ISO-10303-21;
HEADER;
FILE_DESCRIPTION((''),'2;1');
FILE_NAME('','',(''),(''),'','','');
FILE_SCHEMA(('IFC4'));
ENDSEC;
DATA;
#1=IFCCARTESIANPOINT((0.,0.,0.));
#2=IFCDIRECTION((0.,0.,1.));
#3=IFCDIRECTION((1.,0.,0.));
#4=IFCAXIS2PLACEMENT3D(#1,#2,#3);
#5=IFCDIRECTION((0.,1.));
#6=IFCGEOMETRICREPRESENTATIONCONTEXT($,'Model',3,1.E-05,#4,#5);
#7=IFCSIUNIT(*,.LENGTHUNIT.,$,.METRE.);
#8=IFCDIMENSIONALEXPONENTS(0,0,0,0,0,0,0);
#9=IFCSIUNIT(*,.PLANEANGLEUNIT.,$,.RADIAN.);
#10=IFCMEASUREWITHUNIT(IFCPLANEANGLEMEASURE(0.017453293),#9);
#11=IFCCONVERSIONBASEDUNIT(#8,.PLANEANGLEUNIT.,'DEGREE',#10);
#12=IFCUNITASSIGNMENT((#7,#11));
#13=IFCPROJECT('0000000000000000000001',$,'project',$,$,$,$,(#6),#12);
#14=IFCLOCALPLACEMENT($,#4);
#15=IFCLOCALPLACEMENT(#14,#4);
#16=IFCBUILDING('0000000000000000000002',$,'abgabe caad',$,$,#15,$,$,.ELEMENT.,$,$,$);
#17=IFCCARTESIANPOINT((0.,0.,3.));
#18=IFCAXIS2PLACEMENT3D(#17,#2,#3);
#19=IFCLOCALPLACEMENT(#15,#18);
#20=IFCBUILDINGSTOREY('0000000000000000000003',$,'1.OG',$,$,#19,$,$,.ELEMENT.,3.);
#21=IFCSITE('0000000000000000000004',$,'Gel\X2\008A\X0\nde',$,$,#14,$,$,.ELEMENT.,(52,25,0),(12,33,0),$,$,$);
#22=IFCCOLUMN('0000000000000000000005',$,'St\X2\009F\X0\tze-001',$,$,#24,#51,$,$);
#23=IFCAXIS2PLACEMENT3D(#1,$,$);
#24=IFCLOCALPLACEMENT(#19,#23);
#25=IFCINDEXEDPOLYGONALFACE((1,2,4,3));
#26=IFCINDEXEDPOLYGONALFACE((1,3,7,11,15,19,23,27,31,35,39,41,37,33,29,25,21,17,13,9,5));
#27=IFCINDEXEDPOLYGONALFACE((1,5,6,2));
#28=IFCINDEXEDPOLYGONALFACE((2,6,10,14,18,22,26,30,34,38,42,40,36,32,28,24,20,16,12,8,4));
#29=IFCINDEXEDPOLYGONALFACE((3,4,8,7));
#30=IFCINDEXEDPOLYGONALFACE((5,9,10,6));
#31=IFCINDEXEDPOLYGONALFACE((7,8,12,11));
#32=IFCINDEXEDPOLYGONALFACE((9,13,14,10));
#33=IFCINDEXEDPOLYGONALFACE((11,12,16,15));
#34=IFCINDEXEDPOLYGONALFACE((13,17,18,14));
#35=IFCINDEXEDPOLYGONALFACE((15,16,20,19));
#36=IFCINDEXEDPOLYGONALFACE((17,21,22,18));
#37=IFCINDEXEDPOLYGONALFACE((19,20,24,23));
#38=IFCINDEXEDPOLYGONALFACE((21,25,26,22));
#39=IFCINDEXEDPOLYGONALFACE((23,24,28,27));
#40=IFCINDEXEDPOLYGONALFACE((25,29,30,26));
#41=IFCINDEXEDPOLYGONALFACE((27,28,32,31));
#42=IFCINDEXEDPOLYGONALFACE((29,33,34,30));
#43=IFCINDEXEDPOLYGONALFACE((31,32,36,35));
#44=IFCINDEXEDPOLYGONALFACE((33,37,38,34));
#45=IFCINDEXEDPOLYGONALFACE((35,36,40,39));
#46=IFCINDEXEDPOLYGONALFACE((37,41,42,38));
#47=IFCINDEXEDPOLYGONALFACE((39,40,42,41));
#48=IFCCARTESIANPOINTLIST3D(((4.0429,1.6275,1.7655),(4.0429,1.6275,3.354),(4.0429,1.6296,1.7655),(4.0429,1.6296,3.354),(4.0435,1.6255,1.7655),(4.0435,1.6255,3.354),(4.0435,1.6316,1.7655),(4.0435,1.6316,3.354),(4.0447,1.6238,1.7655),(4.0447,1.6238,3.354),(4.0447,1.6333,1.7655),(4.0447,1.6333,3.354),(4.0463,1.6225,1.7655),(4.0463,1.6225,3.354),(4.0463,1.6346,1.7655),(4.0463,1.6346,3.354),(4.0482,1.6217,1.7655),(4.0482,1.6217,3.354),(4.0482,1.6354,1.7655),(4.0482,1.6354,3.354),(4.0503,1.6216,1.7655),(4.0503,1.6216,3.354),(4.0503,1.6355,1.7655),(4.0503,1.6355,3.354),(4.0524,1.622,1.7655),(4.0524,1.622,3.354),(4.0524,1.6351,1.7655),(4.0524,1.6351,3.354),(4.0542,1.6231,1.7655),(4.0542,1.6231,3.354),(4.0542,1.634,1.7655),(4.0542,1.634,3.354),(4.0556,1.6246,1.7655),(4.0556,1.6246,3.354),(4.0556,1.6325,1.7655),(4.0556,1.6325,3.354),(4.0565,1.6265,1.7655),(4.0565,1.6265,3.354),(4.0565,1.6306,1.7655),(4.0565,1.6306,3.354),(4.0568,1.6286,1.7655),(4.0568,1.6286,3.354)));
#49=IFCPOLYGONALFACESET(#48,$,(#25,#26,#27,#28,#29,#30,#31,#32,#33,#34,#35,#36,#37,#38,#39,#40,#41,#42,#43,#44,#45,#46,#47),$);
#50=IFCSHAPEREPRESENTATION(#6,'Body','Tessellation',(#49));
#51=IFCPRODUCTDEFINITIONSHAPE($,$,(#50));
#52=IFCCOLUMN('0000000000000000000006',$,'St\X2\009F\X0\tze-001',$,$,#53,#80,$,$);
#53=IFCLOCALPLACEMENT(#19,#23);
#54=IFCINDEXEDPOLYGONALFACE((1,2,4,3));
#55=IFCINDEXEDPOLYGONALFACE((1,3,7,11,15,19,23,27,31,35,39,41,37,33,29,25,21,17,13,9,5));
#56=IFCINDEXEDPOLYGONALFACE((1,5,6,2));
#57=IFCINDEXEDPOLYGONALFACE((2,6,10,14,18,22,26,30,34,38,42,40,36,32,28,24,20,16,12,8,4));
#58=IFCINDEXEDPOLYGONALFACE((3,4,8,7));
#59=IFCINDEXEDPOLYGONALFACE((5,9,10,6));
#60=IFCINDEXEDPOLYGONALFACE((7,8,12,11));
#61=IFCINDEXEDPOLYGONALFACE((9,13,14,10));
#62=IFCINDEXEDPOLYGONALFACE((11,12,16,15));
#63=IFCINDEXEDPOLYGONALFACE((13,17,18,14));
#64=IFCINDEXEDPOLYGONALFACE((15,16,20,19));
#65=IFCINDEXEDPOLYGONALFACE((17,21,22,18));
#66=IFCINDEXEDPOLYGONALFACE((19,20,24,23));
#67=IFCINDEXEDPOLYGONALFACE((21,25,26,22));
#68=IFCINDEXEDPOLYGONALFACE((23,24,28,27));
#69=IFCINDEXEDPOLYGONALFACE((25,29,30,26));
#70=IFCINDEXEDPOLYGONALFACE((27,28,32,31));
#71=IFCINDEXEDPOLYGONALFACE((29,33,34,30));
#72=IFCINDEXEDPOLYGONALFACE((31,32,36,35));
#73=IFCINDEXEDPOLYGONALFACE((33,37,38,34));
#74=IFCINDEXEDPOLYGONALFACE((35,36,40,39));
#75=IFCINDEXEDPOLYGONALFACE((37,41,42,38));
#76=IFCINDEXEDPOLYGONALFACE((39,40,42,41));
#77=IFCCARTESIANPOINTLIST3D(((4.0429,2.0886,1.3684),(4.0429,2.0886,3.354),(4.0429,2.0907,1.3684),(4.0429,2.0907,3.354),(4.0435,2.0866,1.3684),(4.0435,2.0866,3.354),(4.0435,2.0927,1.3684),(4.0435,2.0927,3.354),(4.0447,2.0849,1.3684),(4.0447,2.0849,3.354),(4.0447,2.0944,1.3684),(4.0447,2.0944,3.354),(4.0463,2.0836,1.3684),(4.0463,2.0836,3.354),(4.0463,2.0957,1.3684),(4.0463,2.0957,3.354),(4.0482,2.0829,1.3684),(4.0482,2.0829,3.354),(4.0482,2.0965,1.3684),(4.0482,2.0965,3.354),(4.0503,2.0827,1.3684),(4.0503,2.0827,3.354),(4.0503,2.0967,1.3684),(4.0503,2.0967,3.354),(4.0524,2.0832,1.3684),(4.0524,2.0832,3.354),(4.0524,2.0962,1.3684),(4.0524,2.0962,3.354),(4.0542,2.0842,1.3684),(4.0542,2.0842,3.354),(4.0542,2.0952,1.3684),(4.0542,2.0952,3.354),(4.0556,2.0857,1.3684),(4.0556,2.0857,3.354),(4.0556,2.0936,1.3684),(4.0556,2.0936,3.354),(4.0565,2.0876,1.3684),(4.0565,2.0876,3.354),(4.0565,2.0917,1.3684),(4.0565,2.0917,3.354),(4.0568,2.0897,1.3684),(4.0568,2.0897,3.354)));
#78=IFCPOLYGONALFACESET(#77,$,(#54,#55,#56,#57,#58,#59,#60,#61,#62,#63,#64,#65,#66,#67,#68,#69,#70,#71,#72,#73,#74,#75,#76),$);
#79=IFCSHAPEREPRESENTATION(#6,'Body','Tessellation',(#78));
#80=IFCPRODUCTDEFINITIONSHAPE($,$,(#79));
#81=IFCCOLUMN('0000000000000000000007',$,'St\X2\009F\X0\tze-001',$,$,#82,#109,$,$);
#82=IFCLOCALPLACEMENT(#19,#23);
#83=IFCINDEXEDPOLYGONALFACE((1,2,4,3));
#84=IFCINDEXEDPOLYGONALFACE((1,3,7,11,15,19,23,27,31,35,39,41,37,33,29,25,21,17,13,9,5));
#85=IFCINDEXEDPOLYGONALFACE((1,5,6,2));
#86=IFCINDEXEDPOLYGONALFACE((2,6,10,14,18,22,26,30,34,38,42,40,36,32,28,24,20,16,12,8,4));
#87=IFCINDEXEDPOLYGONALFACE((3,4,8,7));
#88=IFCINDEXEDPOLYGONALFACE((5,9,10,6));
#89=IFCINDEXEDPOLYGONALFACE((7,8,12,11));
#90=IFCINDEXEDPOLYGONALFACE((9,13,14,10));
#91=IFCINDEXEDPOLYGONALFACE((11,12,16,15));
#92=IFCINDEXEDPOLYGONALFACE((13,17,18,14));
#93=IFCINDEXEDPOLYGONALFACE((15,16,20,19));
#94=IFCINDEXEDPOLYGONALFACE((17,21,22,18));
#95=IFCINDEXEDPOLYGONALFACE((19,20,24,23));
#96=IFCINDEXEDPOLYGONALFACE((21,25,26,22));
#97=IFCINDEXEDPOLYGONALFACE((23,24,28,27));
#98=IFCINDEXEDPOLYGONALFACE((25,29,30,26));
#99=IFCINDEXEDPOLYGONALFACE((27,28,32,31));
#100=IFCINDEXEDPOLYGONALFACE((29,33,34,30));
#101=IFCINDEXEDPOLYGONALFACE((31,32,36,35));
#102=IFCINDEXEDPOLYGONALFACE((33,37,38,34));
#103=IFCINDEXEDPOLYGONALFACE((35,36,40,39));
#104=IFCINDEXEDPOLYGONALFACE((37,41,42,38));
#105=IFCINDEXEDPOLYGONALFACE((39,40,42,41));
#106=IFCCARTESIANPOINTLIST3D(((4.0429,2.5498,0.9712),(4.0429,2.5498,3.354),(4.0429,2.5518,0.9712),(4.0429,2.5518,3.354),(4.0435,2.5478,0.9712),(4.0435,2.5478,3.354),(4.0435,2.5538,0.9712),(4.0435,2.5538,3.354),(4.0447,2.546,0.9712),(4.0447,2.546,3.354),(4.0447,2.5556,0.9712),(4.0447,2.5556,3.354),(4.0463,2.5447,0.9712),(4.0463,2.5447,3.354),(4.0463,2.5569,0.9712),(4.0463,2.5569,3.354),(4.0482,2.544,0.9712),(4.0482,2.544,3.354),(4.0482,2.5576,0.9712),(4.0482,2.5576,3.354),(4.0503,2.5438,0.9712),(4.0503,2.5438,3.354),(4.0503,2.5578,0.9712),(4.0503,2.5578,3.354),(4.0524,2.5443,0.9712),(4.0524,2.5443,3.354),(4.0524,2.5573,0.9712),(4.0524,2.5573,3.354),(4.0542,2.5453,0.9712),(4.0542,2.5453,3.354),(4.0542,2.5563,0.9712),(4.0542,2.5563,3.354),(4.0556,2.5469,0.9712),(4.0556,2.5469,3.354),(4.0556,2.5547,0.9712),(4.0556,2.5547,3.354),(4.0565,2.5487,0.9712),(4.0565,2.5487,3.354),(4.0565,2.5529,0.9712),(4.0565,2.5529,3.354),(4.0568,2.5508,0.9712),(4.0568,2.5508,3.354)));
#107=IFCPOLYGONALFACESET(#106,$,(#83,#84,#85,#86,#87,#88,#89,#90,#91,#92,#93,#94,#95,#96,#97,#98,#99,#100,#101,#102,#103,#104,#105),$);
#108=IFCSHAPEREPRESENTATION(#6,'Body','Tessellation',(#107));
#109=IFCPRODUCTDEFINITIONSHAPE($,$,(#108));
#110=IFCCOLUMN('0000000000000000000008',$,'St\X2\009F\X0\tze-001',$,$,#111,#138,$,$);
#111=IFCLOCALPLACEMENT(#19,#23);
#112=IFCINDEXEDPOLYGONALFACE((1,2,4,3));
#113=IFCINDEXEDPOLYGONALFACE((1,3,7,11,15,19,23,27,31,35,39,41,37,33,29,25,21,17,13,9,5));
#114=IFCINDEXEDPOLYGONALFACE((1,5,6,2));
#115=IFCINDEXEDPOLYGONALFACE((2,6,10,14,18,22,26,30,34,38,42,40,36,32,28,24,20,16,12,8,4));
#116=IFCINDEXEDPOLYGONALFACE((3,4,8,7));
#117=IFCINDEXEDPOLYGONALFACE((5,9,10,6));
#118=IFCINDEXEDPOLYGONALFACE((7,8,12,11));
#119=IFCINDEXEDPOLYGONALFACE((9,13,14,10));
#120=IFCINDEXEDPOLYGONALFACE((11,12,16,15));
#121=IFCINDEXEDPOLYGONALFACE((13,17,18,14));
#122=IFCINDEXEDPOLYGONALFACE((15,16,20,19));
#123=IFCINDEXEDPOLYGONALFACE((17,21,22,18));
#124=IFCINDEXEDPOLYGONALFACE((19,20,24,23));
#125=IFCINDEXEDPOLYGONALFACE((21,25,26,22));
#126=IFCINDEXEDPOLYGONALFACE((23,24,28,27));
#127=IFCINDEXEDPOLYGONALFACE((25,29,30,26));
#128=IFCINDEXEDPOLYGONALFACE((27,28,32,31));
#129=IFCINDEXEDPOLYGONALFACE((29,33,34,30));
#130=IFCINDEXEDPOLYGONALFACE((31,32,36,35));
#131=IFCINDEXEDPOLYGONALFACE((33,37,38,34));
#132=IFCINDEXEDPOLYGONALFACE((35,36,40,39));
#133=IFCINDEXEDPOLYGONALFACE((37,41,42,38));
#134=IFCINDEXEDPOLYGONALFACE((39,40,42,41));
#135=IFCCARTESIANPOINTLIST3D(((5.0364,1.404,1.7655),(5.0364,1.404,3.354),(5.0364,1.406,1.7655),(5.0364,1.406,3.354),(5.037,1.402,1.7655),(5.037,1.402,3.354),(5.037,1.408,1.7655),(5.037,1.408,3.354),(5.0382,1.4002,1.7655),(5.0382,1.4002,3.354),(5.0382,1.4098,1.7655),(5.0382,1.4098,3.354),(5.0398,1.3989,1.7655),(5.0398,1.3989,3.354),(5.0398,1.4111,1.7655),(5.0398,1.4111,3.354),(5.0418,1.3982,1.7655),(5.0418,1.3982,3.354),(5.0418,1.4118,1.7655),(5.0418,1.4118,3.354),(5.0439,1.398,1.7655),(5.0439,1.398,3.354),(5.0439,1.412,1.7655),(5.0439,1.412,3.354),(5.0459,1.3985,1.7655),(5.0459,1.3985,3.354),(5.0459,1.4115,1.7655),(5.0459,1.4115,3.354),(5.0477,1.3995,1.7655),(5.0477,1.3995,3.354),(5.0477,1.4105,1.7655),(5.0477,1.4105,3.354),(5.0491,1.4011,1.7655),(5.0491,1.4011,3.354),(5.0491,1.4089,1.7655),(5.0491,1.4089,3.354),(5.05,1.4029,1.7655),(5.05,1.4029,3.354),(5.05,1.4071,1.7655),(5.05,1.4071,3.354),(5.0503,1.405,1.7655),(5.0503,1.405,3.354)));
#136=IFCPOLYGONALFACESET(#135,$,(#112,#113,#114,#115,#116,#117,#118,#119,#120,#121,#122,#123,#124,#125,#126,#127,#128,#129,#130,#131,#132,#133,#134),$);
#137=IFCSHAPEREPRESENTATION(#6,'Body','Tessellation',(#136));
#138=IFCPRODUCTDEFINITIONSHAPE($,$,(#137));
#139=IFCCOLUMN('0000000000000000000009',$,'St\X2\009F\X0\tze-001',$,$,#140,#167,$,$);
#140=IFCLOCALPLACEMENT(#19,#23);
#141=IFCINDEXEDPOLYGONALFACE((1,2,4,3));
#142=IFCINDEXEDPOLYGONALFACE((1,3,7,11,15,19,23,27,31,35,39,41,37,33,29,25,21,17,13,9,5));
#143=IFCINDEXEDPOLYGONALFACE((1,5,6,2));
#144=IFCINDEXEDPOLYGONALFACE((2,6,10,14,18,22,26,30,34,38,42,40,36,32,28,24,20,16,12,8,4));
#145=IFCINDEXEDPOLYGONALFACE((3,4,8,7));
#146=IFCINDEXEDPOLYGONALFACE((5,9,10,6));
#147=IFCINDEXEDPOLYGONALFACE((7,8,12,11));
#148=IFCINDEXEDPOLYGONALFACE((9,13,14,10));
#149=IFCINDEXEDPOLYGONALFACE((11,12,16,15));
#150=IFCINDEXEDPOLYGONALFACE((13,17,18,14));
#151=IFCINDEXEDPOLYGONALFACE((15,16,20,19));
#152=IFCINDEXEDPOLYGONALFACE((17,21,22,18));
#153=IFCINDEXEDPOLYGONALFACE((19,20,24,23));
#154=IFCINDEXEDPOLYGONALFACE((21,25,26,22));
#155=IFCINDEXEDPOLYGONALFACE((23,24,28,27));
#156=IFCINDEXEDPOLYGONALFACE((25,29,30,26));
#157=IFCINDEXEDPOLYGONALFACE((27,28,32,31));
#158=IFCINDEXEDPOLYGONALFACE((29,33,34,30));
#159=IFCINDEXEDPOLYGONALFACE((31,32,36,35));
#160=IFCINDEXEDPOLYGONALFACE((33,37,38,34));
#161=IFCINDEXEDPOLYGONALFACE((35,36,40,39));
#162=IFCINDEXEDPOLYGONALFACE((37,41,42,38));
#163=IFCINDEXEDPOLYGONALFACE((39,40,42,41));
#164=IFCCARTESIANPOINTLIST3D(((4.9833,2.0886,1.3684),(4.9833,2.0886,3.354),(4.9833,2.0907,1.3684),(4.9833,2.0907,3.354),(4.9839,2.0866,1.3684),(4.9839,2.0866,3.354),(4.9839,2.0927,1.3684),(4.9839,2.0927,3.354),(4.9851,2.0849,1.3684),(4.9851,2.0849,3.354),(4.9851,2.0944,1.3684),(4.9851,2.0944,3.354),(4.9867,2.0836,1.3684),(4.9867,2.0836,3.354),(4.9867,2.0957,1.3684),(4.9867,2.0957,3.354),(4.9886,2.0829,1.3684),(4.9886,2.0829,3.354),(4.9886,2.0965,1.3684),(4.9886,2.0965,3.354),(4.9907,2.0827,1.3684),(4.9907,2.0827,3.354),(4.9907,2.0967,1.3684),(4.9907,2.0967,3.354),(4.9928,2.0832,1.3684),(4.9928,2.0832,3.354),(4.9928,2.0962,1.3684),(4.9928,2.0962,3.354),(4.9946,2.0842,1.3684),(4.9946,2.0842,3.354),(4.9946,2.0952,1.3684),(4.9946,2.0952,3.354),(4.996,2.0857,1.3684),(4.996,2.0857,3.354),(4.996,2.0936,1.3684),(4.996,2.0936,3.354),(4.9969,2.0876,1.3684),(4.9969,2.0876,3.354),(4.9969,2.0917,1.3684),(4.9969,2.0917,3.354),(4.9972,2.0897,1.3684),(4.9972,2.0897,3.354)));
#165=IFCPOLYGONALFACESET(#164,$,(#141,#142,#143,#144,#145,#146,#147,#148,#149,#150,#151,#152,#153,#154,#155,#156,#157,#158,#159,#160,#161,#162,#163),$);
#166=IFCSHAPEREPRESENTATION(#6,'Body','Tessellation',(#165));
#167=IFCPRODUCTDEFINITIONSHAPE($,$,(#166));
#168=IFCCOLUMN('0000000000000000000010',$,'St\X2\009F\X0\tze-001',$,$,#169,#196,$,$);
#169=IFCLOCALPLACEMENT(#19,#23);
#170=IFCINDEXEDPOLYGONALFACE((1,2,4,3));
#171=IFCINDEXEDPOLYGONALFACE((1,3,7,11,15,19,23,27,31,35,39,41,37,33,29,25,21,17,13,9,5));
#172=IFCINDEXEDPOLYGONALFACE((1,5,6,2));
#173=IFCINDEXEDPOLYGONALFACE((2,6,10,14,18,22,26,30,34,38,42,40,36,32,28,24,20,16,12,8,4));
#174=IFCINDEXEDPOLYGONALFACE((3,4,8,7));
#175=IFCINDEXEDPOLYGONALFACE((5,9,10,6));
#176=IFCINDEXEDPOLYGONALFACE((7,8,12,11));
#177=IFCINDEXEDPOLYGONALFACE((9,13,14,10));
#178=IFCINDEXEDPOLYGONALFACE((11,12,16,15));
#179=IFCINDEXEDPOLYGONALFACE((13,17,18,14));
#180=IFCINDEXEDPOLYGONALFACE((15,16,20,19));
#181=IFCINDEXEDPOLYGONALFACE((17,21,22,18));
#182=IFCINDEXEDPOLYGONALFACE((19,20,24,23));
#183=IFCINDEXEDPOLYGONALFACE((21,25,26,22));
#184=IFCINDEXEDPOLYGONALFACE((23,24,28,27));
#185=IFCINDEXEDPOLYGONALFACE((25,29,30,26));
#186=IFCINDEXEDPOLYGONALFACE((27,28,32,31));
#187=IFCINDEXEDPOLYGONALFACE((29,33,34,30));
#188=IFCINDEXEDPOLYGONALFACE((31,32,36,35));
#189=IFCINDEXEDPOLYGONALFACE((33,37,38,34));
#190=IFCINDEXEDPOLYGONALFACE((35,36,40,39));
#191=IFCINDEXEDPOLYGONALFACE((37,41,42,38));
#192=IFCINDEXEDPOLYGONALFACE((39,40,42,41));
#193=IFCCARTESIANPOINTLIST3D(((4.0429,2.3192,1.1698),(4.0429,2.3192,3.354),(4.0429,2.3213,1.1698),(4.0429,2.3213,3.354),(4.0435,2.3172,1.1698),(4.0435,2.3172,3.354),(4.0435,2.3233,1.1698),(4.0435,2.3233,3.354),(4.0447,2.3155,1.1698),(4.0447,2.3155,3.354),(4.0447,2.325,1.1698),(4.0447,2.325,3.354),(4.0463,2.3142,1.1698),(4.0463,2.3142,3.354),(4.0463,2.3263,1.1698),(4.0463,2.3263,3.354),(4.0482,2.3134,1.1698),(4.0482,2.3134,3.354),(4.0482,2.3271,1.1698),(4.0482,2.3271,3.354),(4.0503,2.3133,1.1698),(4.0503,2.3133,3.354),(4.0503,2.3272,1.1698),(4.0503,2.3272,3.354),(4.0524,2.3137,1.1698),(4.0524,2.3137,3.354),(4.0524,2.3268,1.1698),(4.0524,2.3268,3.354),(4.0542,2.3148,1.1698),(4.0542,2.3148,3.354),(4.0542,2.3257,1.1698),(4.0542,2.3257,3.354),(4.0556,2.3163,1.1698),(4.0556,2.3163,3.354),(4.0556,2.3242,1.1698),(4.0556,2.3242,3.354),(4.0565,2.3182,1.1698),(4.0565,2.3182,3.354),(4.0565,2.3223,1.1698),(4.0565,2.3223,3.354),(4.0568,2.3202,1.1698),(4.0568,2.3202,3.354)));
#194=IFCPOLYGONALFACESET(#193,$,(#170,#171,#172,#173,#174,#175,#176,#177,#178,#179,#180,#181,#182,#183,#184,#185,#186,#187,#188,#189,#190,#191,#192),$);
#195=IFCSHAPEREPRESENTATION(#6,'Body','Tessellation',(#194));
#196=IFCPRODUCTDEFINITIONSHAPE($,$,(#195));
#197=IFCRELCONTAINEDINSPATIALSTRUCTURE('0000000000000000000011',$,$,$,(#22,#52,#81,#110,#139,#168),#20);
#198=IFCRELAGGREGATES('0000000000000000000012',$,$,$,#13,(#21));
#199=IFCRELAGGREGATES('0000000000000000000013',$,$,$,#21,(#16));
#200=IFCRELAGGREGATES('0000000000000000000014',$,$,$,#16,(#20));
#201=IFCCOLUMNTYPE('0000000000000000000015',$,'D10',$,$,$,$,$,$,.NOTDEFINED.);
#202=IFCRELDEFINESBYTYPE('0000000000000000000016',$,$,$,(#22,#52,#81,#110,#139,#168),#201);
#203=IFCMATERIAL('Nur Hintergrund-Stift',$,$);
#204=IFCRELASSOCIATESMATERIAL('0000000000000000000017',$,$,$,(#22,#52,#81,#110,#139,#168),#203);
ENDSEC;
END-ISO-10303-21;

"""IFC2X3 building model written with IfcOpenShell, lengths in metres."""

from ifc_helpers import new_model, entity, si_unit, converted_unit, direction, frame, origin_with_axes, origin_2d_with_axis, place, context, project, spatial, circle, extrude, material, type_object, element, save


model = new_model("IFC2X3")

# Units and contexts
model_context = context("Model", 3, precision=1e-05, world=origin_with_axes(), true_north=direction((0.0, 1.0)))
ifc_project = project(units=[si_unit("LENGTHUNIT", "METRE"), converted_unit("PLANEANGLEUNIT", "DEGREE", entity("IfcPlaneAngleMeasure", 0.017453293), si_unit("PLANEANGLEUNIT", "RADIAN"), dimensions=[0, 0, 0, 0, 0, 0, 0])], contexts=[model_context])

# Site, building, storey
site_placement = place(None, origin_with_axes())
site = spatial("IfcSite", under=ifc_project, at=site_placement, Name="Gel\u008ande", CompositionType="ELEMENT", RefLatitude=(52, 25, 0), RefLongitude=(12, 33, 0))
building_placement = place(site_placement, origin_with_axes())
building = spatial("IfcBuilding", under=site, at=building_placement, Name="abgabe caad", CompositionType="ELEMENT")
storey_placement = place(building_placement, frame((0.0, 0.0, 3.0), z_axis=(0.0, 0.0, 1.0), x_axis=(1.0, 0.0, 0.0)))
storey = spatial("IfcBuildingStorey", under=building, at=storey_placement, Name="1.OG", CompositionType="ELEMENT", Elevation=3.0)

# Columns
ifc_material_1 = material(Name="Nur Hintergrund-Stift")
column_type = type_object("IfcColumnType", Name="D10", PredefinedType="NOTDEFINED")
column_1_placement = place(storey_placement, frame((4.0498, 1.6286, 1.7655), z_axis=(0.0, 0.0, 1.0), x_axis=(1.0, 0.0, 0.0)))
element("IfcColumn", 1, at=column_1_placement, inside=storey, type_object=column_type, material=ifc_material_1, Name="St\u009ftze-001", context=model_context, shape_type="SweptSolid", body=[
    extrude(circle(Radius=0.007, at=origin_2d_with_axis()), origin_with_axes(), (0.0, 0.0, 1.0), 1.5885),
])
column_2_placement = place(storey_placement, frame((4.0498, 2.0897, 1.3684), z_axis=(0.0, 0.0, 1.0), x_axis=(1.0, 0.0, 0.0)))
element("IfcColumn", 2, at=column_2_placement, inside=storey, type_object=column_type, material=ifc_material_1, Name="St\u009ftze-001", context=model_context, shape_type="SweptSolid", body=[
    extrude(circle(Radius=0.007, at=origin_2d_with_axis()), origin_with_axes(), (0.0, 0.0, 1.0), 1.9856),
])
column_3_placement = place(storey_placement, frame((4.0498, 2.5508, 0.9712), z_axis=(0.0, 0.0, 1.0), x_axis=(1.0, 0.0, 0.0)))
element("IfcColumn", 3, at=column_3_placement, inside=storey, type_object=column_type, material=ifc_material_1, Name="St\u009ftze-001", context=model_context, shape_type="SweptSolid", body=[
    extrude(circle(Radius=0.007, at=origin_2d_with_axis()), origin_with_axes(), (0.0, 0.0, 1.0), 2.3828),
])
column_4_placement = place(storey_placement, frame((5.0433, 1.405, 1.7655), z_axis=(0.0, 0.0, 1.0), x_axis=(1.0, 0.0, 0.0)))
element("IfcColumn", 4, at=column_4_placement, inside=storey, type_object=column_type, material=ifc_material_1, Name="St\u009ftze-001", context=model_context, shape_type="SweptSolid", body=[
    extrude(circle(Radius=0.007, at=origin_2d_with_axis()), origin_with_axes(), (0.0, 0.0, 1.0), 1.5885),
])
column_5_placement = place(storey_placement, frame((4.9902, 2.0897, 1.3684), z_axis=(0.0, 0.0, 1.0), x_axis=(1.0, 0.0, 0.0)))
element("IfcColumn", 5, at=column_5_placement, inside=storey, type_object=column_type, material=ifc_material_1, Name="St\u009ftze-001", context=model_context, shape_type="SweptSolid", body=[
    extrude(circle(Radius=0.007, at=origin_2d_with_axis()), origin_with_axes(), (0.0, 0.0, 1.0), 1.9856),
])
column_6_placement = place(storey_placement, frame((4.0498, 2.3202, 1.1698), z_axis=(0.0, 0.0, 1.0), x_axis=(1.0, 0.0, 0.0)))
element("IfcColumn", 6, at=column_6_placement, inside=storey, type_object=column_type, material=ifc_material_1, Name="St\u009ftze-001", context=model_context, shape_type="SweptSolid", body=[
    extrude(circle(Radius=0.007, at=origin_2d_with_axis()), origin_with_axes(), (0.0, 0.0, 1.0), 2.1842),
])

save(model, "model.ifc")
